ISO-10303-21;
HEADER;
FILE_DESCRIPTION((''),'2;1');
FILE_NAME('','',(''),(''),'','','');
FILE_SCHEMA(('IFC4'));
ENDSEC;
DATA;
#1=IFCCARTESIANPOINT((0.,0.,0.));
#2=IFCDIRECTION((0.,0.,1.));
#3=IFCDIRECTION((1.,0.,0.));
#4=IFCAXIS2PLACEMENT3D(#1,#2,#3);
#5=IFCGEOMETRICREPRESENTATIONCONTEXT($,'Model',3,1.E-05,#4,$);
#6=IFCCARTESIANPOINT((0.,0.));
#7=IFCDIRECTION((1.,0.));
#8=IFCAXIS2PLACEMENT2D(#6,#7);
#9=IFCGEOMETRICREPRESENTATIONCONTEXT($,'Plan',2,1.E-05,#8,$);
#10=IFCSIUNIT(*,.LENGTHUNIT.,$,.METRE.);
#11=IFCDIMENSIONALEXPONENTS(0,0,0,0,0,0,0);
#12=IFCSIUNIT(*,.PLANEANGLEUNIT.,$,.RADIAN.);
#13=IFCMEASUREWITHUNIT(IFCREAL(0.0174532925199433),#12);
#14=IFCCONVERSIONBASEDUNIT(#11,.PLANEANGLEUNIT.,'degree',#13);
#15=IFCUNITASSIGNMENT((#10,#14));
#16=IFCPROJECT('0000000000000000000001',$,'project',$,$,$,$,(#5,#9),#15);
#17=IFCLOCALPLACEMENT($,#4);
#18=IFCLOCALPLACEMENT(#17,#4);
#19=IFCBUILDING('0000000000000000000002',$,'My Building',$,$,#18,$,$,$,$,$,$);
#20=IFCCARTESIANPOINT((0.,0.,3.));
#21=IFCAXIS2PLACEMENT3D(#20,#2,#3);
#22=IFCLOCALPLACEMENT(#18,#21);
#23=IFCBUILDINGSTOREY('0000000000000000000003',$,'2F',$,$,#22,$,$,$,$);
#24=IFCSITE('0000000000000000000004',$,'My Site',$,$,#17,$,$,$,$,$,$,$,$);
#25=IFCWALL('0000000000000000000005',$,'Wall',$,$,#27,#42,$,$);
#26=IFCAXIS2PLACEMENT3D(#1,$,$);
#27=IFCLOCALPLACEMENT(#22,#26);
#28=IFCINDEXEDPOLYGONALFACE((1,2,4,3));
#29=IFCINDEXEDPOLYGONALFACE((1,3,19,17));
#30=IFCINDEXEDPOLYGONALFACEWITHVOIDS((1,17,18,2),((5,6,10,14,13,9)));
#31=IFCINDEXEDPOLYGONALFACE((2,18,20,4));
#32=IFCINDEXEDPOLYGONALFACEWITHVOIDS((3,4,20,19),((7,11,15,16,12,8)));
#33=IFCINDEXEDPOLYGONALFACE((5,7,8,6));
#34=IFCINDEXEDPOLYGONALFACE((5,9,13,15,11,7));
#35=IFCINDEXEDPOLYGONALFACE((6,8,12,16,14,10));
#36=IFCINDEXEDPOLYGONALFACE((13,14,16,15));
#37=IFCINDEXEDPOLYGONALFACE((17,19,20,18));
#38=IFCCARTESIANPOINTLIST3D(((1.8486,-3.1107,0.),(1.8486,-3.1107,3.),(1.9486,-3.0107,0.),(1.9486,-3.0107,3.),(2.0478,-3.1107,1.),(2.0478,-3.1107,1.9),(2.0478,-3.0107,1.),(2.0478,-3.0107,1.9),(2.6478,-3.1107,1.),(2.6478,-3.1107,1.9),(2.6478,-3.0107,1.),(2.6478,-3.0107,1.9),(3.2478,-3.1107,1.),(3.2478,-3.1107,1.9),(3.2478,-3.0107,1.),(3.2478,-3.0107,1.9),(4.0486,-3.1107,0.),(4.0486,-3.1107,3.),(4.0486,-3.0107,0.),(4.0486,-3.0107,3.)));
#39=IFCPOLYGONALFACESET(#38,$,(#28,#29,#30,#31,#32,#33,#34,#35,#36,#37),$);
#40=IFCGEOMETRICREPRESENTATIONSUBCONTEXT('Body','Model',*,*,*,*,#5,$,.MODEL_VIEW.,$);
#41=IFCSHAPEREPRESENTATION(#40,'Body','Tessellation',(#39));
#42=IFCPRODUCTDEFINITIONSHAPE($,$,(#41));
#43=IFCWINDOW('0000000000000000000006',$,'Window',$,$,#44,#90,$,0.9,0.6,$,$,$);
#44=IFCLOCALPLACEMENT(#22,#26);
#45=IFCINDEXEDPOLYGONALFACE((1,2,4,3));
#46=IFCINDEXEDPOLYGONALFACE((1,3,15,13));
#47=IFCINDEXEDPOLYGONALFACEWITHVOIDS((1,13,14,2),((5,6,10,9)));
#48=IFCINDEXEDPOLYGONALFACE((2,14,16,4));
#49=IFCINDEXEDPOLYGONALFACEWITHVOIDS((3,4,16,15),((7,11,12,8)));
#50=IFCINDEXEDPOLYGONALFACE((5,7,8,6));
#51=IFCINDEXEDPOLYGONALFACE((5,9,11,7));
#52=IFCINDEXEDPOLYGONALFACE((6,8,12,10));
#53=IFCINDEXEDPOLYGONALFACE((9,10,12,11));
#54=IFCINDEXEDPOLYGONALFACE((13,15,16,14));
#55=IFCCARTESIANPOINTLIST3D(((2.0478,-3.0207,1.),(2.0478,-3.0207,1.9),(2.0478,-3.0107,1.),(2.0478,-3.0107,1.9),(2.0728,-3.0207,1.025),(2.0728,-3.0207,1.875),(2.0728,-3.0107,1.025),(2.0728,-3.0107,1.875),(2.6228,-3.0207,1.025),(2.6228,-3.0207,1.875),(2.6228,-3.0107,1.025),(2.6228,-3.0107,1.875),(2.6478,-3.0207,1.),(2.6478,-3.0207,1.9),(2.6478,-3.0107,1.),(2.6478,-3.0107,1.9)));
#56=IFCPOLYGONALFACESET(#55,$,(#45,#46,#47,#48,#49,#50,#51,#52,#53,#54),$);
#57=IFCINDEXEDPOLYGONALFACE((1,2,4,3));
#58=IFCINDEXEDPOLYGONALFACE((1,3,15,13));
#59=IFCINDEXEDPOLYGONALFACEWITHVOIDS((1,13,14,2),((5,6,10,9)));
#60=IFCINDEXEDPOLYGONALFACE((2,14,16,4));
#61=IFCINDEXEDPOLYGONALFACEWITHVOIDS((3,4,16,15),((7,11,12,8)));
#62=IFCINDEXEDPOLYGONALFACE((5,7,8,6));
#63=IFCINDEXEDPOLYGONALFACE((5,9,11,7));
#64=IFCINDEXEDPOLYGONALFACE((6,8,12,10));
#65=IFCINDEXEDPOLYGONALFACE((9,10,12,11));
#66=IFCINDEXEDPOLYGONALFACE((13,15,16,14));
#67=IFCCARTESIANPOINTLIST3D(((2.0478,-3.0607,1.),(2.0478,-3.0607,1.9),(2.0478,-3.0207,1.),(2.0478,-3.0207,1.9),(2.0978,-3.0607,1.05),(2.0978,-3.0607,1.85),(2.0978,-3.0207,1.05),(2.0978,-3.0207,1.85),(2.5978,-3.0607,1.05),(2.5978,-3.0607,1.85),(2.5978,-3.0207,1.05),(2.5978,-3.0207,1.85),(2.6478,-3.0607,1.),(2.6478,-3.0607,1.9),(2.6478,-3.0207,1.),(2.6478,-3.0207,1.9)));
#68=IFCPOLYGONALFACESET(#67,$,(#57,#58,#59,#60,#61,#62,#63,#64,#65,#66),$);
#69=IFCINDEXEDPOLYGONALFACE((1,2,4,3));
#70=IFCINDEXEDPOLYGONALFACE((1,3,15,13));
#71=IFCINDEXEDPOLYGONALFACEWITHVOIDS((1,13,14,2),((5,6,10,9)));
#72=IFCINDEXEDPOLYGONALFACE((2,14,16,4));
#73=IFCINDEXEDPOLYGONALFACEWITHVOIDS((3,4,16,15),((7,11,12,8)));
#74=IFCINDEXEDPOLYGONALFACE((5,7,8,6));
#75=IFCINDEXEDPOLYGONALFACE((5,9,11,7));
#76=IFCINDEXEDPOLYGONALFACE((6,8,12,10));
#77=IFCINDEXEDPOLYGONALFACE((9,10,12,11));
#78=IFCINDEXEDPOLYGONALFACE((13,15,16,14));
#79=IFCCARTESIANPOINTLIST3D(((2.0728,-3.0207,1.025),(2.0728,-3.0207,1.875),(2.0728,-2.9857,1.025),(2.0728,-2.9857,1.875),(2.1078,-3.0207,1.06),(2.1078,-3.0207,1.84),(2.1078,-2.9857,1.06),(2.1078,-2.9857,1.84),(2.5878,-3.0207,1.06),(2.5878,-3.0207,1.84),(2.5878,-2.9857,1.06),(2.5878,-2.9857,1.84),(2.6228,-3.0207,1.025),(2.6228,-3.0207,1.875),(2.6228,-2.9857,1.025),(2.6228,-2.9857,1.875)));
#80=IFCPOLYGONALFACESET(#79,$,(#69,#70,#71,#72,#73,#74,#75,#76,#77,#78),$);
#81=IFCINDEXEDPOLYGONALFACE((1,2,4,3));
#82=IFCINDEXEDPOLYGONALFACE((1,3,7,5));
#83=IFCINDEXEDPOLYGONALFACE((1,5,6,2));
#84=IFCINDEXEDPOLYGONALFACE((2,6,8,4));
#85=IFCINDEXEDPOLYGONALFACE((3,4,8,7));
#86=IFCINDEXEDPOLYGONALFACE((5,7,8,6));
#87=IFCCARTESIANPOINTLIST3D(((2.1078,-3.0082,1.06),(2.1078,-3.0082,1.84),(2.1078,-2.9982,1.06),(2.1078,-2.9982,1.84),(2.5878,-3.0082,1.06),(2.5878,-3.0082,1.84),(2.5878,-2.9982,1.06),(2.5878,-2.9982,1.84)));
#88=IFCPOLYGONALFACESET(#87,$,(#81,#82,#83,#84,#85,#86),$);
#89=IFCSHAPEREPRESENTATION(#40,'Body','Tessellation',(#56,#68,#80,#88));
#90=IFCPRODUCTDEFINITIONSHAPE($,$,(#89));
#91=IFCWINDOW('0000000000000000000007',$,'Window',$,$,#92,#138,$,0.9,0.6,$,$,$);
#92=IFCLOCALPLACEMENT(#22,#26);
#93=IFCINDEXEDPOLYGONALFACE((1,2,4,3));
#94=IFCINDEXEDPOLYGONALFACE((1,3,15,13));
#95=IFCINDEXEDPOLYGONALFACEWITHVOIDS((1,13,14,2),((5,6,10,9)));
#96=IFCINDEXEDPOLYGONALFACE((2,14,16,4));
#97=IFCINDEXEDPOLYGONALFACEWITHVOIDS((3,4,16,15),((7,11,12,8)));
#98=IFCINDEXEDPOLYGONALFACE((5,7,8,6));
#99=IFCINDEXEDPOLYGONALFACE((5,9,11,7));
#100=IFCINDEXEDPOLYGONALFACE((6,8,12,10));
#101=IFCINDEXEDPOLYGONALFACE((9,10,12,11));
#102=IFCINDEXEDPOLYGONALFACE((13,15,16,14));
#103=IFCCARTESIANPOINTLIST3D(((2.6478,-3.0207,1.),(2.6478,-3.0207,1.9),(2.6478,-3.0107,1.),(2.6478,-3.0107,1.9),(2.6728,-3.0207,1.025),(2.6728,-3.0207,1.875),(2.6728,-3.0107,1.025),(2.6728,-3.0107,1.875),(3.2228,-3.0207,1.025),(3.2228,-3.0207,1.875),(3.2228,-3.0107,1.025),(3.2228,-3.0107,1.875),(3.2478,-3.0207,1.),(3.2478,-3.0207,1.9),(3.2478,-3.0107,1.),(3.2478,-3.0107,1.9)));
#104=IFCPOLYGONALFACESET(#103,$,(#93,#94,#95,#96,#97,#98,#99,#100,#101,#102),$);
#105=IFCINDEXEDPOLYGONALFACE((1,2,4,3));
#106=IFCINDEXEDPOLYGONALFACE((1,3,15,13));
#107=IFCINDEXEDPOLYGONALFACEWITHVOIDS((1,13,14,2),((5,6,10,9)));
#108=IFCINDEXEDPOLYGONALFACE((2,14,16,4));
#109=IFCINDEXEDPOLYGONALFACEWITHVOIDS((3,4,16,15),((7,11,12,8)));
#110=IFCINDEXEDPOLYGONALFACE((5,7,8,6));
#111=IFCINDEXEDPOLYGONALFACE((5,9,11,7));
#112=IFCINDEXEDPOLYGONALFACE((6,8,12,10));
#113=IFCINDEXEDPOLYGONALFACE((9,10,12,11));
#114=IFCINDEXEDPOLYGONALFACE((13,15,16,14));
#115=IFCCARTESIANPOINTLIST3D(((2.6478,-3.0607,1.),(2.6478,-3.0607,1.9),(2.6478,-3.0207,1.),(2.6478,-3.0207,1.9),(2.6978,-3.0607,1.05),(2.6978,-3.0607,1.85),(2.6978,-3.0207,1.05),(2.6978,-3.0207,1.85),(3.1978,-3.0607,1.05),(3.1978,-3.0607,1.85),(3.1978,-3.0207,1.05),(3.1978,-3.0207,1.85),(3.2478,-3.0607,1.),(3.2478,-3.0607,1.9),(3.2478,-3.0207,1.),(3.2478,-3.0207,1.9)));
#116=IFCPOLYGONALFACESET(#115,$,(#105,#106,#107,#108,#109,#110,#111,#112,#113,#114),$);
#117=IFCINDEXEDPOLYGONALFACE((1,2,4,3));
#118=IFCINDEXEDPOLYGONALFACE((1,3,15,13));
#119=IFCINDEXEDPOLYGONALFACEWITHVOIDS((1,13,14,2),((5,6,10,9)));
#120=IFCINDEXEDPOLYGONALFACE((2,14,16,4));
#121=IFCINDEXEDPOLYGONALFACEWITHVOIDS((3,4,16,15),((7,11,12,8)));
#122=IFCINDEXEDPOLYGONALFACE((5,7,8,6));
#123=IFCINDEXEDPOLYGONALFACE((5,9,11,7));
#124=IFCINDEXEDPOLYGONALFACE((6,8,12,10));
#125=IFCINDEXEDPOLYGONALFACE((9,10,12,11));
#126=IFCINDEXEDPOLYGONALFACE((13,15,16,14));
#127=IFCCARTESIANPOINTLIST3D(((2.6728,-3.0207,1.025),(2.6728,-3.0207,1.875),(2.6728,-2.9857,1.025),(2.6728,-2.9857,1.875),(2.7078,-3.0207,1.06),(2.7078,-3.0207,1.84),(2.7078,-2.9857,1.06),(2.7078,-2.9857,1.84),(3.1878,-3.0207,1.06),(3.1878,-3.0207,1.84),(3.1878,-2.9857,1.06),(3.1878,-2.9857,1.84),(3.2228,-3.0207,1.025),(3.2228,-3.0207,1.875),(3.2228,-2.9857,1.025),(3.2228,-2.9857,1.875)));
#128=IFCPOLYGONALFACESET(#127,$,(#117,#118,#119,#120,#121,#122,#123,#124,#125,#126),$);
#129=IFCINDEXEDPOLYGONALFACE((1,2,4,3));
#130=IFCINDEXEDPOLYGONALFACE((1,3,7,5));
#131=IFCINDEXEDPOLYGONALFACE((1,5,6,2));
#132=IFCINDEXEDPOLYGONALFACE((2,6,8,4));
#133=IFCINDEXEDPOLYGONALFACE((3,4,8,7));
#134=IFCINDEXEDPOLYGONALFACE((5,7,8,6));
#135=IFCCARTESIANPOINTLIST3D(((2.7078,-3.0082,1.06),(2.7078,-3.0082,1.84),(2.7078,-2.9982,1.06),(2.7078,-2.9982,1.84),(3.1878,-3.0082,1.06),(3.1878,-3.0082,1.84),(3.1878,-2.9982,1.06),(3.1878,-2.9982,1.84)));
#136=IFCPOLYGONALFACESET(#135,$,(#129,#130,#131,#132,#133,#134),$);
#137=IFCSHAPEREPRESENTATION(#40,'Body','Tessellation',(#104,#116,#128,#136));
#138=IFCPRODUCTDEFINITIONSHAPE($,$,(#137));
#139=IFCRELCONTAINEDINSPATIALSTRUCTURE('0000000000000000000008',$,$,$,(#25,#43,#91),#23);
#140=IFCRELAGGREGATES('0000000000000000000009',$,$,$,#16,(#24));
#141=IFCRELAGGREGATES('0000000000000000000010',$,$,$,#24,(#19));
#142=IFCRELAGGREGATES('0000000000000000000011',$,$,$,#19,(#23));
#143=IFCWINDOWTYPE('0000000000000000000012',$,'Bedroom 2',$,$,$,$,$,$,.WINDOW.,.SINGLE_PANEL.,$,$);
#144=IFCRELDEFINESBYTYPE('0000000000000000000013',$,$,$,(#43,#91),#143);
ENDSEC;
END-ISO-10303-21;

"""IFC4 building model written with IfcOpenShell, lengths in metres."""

from ifc_helpers import new_model, entity, si_unit, converted_unit, frame, origin_with_axes, origin_2d_with_axis, place, context, subcontext, project, spatial, line, indexed_curve, outline, extrude, shape, source, transform, mapped, type_object, type_shapes, element, fill, save


model = new_model("IFC4")

# Units and contexts
model_context = context("Model", 3, precision=1e-05, world=origin_with_axes())
plan_context = context("Plan", 2, precision=1e-05, world=origin_2d_with_axis())
body_context_1 = subcontext(model_context, "Body", "Model", "MODEL_VIEW")
body_context_2 = subcontext(plan_context, "Body", "Plan", "PLAN_VIEW")
ifc_project = project(units=[si_unit("LENGTHUNIT", "METRE"), converted_unit("PLANEANGLEUNIT", "degree", entity("IfcReal", 0.0174532925199433), si_unit("PLANEANGLEUNIT", "RADIAN"), dimensions=[0, 0, 0, 0, 0, 0, 0])], contexts=[model_context, plan_context])

# Site, building, storey
site_placement = place(None, origin_with_axes())
site = spatial("IfcSite", under=ifc_project, at=site_placement, Name="My Site")
building_placement = place(site_placement, origin_with_axes())
building = spatial("IfcBuilding", under=site, at=building_placement, Name="My Building")
storey_placement = place(building_placement, frame((0.0, 0.0, 3.0), z_axis=(0.0, 0.0, 1.0), x_axis=(1.0, 0.0, 0.0)))
storey = spatial("IfcBuildingStorey", under=building, at=storey_placement, Name="2F")

# Wall, openings, windows
wall_1_placement = place(storey_placement, frame((1.8486, -3.1107, 0.0), z_axis=(0.0, 0.0, 1.0), x_axis=(1.0, 0.0, 0.0)))
wall_1 = element("IfcWall", 1, at=wall_1_placement, inside=storey, Name="Wall", context=body_context_1, shape_type="SweptSolid", body=[
    extrude(outline(indexed_curve([(0.0, 0.0), (0.1, 0.1), (2.2, 0.1), (2.2, 0.0)], segments=[line(1, 2, 3, 4, 1)])), origin_with_axes(), (0.0, 0.0, 1.0), 3.0),
])
shared_shape_1 = source(origin_with_axes(), body_context_1, "Body", "SweptSolid", [
    extrude(outline(indexed_curve([(0.0, 0.0), (0.6, 0.0), (0.6, 0.9), (0.0, 0.9)], segments=[line(1, 2, 3, 4, 1)])), frame((0.0, -0.6, 0.0), z_axis=(0.0, -1.0, 0.0), x_axis=(1.0, 0.0, 0.0)), (0.0, 0.0, -1.0), 1.2),
])
opening_1_placement = place(wall_1_placement, frame((0.1992, 0.0, 1.0), z_axis=(0.0, 0.0, 1.0), x_axis=(1.0, 0.0, 0.0)))
opening_1 = element("IfcOpeningElement", 2, at=opening_1_placement, cuts=wall_1, PredefinedType="OPENING", context=body_context_1, shape_type="MappedRepresentation", body=[
    mapped(shared_shape_1, transform((0.0, 0.0, 0.0), x_axis=(1.0, 0.0, 0.0), y_axis=(0.0, 1.0, 0.0), z_axis=(0.0, 0.0, 1.0), scale=1.0)),
])
opening_2_placement = place(wall_1_placement, frame((0.7992, 0.0, 1.0), z_axis=(0.0, 0.0, 1.0), x_axis=(1.0, 0.0, 0.0)))
opening_2 = element("IfcOpeningElement", 3, at=opening_2_placement, cuts=wall_1, PredefinedType="OPENING", context=body_context_1, shape_type="MappedRepresentation", body=[
    mapped(shared_shape_1, transform((0.0, 0.0, 0.0), x_axis=(1.0, 0.0, 0.0), y_axis=(0.0, 1.0, 0.0), z_axis=(0.0, 0.0, 1.0), scale=1.0)),
])
window_type_1 = type_object("IfcWindowType", Name="Bedroom 2", PartitioningType="SINGLE_PANEL", PredefinedType="WINDOW")
shared_shape_2 = source(origin_with_axes(), body_context_1, "Body", "SweptSolid", [
    extrude(outline(indexed_curve([(0.0, 0.0), (0.6, 0.0), (0.6, 0.9), (0.0, 0.9)], segments=[line(1, 2, 3, 4, 1)]), holes=[indexed_curve([(0.025, 0.025), (0.575, 0.025), (0.575, 0.875), (0.025, 0.875)], segments=[line(1, 2, 3, 4, 1)])]), frame((0.0, 0.09, 0.0), z_axis=(0.0, -1.0, 0.0), x_axis=(1.0, 0.0, 0.0)), (0.0, 0.0, -1.0), 0.01),
    extrude(outline(indexed_curve([(0.0, 0.0), (0.6, 0.0), (0.6, 0.9), (0.0, 0.9)], segments=[line(1, 2, 3, 4, 1)]), holes=[indexed_curve([(0.05, 0.05), (0.55, 0.05), (0.55, 0.85), (0.05, 0.85)], segments=[line(1, 2, 3, 4, 1)])]), frame((0.0, 0.05, 0.0), z_axis=(0.0, -1.0, 0.0), x_axis=(1.0, 0.0, 0.0)), (0.0, 0.0, -1.0), 0.04),
    extrude(outline(indexed_curve([(0.0, 0.0), (0.55, 0.0), (0.55, 0.85), (0.0, 0.85)], segments=[line(1, 2, 3, 4, 1)]), holes=[indexed_curve([(0.035, 0.035), (0.515, 0.035), (0.515, 0.815), (0.035, 0.815)], segments=[line(1, 2, 3, 4, 1)])]), frame((0.025, 0.09, 0.025), z_axis=(0.0, -1.0, 0.0), x_axis=(1.0, 0.0, 0.0)), (0.0, 0.0, -1.0), 0.035),
    extrude(outline(indexed_curve([(0.035, 0.035), (0.515, 0.035), (0.515, 0.815), (0.035, 0.815)], segments=[line(1, 2, 3, 4, 1)])), frame((0.025, 0.1025, 0.025), z_axis=(0.0, -1.0, 0.0), x_axis=(1.0, 0.0, 0.0)), (0.0, 0.0, -1.0), 0.01),
])
shared_shape_3 = source(origin_with_axes(), body_context_2, "Body", "Curve2D", [
    entity("IfcIndexedPolyCurve", entity("IfcCartesianPointList2D", [[0.05, 0.05], [0.55, 0.05]])),
    entity("IfcIndexedPolyCurve", entity("IfcCartesianPointList2D", [[0.0, 0.1], [0.025, 0.1], [0.025, 0.09], [0.05, 0.09], [0.05, 0.05], [0.0, 0.05]]), [entity("IfcLineIndex", [1, 2, 3, 4, 5, 6, 1])]),
    entity("IfcIndexedPolyCurve", entity("IfcCartesianPointList2D", [[0.6, 0.1], [0.575, 0.1], [0.575, 0.09], [0.55, 0.09], [0.55, 0.05], [0.6, 0.05]]), [entity("IfcLineIndex", [1, 2, 3, 4, 5, 6, 1])]),
    entity("IfcIndexedPolyCurve", entity("IfcCartesianPointList2D", [[0.025, 0.09], [0.06, 0.09], [0.06, 0.125], [0.025, 0.125]]), [entity("IfcLineIndex", [1, 2, 3, 4, 1])]),
    entity("IfcIndexedPolyCurve", entity("IfcCartesianPointList2D", [[0.575, 0.09], [0.54, 0.09], [0.54, 0.125], [0.575, 0.125]]), [entity("IfcLineIndex", [1, 2, 3, 4, 1])]),
    entity("IfcIndexedPolyCurve", entity("IfcCartesianPointList2D", [[0.06, 0.09], [0.54, 0.09]])),
    entity("IfcIndexedPolyCurve", entity("IfcCartesianPointList2D", [[0.06, 0.125], [0.54, 0.125]])),
    entity("IfcIndexedPolyCurve", entity("IfcCartesianPointList2D", [[0.06, 0.1075], [0.54, 0.1075]])),
])
type_shapes(window_type_1, [shared_shape_2, shared_shape_3])
window_1_placement = place(opening_1_placement, origin_with_axes())
window_1 = element("IfcWindow", 4, at=window_1_placement, inside=storey, type_object=window_type_1, Name="Window", OverallHeight=0.9, OverallWidth=0.6, shapes=[
    shape(body_context_1, "Body", "MappedRepresentation", [mapped(shared_shape_2, transform((0.0, 0.0, 0.0), x_axis=(1.0, 0.0, 0.0), y_axis=(0.0, 1.0, 0.0), z_axis=(0.0, 0.0, 1.0), scale=1.0))]),
    shape(body_context_2, "Body", "MappedRepresentation", [mapped(shared_shape_3, transform((0.0, 0.0, 0.0), x_axis=(1.0, 0.0, 0.0), y_axis=(0.0, 1.0, 0.0), z_axis=(0.0, 0.0, 1.0), scale=1.0))]),
])
fill(opening_1, window_1)
window_2_placement = place(opening_2_placement, origin_with_axes())
window_2 = element("IfcWindow", 5, at=window_2_placement, inside=storey, type_object=window_type_1, Name="Window", OverallHeight=0.9, OverallWidth=0.6, shapes=[
    shape(body_context_1, "Body", "MappedRepresentation", [mapped(shared_shape_2, transform((0.0, 0.0, 0.0), x_axis=(1.0, 0.0, 0.0), y_axis=(0.0, 1.0, 0.0), z_axis=(0.0, 0.0, 1.0), scale=1.0))]),
    shape(body_context_2, "Body", "MappedRepresentation", [mapped(shared_shape_3, transform((0.0, 0.0, 0.0), x_axis=(1.0, 0.0, 0.0), y_axis=(0.0, 1.0, 0.0), z_axis=(0.0, 0.0, 1.0), scale=1.0))]),
])
fill(opening_2, window_2)

save(model, "model.ifc")
